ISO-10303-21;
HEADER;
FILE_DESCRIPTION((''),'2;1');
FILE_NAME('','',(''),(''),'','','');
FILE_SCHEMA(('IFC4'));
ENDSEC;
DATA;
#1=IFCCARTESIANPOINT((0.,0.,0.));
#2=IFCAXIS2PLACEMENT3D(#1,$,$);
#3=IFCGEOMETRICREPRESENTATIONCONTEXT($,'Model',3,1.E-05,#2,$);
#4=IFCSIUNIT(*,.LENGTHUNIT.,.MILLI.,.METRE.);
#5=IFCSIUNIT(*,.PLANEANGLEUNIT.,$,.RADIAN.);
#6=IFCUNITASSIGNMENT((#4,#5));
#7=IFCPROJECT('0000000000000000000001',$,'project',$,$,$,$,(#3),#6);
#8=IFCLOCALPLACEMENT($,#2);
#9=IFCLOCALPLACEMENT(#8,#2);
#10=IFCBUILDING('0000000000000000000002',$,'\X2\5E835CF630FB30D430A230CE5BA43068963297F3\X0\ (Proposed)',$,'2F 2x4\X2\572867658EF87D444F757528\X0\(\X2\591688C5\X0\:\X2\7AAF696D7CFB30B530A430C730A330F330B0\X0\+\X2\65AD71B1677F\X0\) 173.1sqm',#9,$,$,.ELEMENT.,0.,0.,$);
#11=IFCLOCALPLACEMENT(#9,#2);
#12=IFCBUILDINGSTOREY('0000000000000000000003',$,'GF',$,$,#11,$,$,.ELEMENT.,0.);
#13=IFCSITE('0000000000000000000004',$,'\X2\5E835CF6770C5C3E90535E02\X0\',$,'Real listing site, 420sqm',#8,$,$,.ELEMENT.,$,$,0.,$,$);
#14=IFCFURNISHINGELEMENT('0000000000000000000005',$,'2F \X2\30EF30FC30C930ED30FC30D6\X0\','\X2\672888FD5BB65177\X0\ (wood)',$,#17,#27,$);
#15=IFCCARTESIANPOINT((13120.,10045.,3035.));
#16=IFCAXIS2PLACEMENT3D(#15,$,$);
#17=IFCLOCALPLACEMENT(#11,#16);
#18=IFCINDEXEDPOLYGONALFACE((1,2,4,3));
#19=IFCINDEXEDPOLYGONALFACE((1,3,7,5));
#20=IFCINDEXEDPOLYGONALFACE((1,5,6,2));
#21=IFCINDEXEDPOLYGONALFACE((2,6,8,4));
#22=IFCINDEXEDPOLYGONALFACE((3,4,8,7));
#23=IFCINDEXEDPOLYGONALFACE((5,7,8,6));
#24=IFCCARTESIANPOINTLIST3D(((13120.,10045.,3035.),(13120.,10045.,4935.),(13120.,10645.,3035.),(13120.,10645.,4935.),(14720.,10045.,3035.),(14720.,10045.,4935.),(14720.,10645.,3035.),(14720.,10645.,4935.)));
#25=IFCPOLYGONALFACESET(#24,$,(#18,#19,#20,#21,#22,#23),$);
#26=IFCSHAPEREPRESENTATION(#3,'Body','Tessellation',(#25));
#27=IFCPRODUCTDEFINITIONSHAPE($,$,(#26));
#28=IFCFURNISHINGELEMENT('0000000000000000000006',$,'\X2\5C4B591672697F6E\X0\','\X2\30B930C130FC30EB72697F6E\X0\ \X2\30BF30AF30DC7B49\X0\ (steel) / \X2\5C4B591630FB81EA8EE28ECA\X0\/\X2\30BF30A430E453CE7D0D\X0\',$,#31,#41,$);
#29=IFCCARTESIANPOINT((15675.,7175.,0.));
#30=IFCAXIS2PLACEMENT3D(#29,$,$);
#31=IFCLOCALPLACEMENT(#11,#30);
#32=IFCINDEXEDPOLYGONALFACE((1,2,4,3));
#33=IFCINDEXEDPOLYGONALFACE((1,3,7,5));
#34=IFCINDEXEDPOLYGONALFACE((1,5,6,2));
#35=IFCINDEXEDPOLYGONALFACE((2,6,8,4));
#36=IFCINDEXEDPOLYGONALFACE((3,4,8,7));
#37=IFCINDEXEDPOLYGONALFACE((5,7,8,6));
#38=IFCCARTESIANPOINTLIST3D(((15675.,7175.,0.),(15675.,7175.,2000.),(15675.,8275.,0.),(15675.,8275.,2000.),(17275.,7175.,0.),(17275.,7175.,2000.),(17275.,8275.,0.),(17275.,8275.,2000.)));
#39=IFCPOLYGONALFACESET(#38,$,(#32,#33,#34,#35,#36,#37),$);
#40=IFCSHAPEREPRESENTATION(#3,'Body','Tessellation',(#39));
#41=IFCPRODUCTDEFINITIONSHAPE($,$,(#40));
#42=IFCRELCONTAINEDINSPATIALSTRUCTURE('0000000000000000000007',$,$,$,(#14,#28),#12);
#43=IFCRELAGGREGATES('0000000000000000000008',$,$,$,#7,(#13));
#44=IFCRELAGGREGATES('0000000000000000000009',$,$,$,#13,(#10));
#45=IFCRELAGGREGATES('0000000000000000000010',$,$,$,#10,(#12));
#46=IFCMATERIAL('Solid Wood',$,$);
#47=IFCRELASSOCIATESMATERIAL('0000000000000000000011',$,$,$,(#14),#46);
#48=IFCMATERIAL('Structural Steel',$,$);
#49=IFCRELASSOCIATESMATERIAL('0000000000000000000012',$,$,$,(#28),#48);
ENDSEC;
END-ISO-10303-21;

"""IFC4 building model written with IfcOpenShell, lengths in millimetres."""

from ifc_helpers import new_model, si_unit, frame, frame_2d, origin, place, context, project, spatial, rectangle, extrude, material, element, save


model = new_model("IFC4")

# Units and contexts
model_context = context("Model", 3, precision=1e-05, world=origin())
ifc_project = project(units=[si_unit("LENGTHUNIT", "METRE", prefix="MILLI"), si_unit("PLANEANGLEUNIT", "RADIAN")], contexts=[model_context])

# Site, building, storey
site_placement = place(None, origin())
site = spatial("IfcSite", under=ifc_project, at=site_placement, Name="広島県尾道市", ObjectType="Real listing site, 420sqm", CompositionType="ELEMENT", RefElevation=0.0)
building_placement = place(site_placement, origin())
building = spatial("IfcBuilding", under=site, at=building_placement, Name="広島・ピアノ室と防音 (Proposed)", ObjectType="2F 2x4在来軸組併用(外装:窯業系サイディング+断熱板) 173.1sqm", CompositionType="ELEMENT", ElevationOfRefHeight=0.0, ElevationOfTerrain=0.0)
storey_placement = place(building_placement, origin())
storey = spatial("IfcBuildingStorey", under=building, at=storey_placement, Name="GF", CompositionType="ELEMENT", Elevation=0.0)

# Shared definitions
ifc_material_1 = material(Name="Solid Wood")

# Shared definitions
ifc_material_2 = material(Name="Structural Steel")

# Furnishing elements
furnishing_1_placement = place(storey_placement, frame((13120.0, 10045.0, 3035.0)))
element("IfcFurnishingElement", 1, at=furnishing_1_placement, inside=storey, material=ifc_material_1, Name="2F ワードローブ", Description="木製家具 (wood)", context=model_context, shape_type="SweptSolid", body=[
    extrude(rectangle(XDim=1600.0, YDim=600.0, at=frame_2d((800.0, 300.0))), frame((13120.0, 10045.0, 3035.0)), (0.0, 0.0, 1.0), 1900.0),
])
furnishing_2_placement = place(storey_placement, frame((15675.0, 7175.0, 0.0)))
element("IfcFurnishingElement", 2, at=furnishing_2_placement, inside=storey, material=ifc_material_2, Name="屋外物置", Description="スチール物置 タクボ等 (steel) / 屋外・自転車/タイヤ収納", context=model_context, shape_type="SweptSolid", body=[
    extrude(rectangle(XDim=1600.0, YDim=1100.0, at=frame_2d((800.0, 550.0))), frame((15675.0, 7175.0, 0.0)), (0.0, 0.0, 1.0), 2000.0),
])

save(model, "model.ifc")
